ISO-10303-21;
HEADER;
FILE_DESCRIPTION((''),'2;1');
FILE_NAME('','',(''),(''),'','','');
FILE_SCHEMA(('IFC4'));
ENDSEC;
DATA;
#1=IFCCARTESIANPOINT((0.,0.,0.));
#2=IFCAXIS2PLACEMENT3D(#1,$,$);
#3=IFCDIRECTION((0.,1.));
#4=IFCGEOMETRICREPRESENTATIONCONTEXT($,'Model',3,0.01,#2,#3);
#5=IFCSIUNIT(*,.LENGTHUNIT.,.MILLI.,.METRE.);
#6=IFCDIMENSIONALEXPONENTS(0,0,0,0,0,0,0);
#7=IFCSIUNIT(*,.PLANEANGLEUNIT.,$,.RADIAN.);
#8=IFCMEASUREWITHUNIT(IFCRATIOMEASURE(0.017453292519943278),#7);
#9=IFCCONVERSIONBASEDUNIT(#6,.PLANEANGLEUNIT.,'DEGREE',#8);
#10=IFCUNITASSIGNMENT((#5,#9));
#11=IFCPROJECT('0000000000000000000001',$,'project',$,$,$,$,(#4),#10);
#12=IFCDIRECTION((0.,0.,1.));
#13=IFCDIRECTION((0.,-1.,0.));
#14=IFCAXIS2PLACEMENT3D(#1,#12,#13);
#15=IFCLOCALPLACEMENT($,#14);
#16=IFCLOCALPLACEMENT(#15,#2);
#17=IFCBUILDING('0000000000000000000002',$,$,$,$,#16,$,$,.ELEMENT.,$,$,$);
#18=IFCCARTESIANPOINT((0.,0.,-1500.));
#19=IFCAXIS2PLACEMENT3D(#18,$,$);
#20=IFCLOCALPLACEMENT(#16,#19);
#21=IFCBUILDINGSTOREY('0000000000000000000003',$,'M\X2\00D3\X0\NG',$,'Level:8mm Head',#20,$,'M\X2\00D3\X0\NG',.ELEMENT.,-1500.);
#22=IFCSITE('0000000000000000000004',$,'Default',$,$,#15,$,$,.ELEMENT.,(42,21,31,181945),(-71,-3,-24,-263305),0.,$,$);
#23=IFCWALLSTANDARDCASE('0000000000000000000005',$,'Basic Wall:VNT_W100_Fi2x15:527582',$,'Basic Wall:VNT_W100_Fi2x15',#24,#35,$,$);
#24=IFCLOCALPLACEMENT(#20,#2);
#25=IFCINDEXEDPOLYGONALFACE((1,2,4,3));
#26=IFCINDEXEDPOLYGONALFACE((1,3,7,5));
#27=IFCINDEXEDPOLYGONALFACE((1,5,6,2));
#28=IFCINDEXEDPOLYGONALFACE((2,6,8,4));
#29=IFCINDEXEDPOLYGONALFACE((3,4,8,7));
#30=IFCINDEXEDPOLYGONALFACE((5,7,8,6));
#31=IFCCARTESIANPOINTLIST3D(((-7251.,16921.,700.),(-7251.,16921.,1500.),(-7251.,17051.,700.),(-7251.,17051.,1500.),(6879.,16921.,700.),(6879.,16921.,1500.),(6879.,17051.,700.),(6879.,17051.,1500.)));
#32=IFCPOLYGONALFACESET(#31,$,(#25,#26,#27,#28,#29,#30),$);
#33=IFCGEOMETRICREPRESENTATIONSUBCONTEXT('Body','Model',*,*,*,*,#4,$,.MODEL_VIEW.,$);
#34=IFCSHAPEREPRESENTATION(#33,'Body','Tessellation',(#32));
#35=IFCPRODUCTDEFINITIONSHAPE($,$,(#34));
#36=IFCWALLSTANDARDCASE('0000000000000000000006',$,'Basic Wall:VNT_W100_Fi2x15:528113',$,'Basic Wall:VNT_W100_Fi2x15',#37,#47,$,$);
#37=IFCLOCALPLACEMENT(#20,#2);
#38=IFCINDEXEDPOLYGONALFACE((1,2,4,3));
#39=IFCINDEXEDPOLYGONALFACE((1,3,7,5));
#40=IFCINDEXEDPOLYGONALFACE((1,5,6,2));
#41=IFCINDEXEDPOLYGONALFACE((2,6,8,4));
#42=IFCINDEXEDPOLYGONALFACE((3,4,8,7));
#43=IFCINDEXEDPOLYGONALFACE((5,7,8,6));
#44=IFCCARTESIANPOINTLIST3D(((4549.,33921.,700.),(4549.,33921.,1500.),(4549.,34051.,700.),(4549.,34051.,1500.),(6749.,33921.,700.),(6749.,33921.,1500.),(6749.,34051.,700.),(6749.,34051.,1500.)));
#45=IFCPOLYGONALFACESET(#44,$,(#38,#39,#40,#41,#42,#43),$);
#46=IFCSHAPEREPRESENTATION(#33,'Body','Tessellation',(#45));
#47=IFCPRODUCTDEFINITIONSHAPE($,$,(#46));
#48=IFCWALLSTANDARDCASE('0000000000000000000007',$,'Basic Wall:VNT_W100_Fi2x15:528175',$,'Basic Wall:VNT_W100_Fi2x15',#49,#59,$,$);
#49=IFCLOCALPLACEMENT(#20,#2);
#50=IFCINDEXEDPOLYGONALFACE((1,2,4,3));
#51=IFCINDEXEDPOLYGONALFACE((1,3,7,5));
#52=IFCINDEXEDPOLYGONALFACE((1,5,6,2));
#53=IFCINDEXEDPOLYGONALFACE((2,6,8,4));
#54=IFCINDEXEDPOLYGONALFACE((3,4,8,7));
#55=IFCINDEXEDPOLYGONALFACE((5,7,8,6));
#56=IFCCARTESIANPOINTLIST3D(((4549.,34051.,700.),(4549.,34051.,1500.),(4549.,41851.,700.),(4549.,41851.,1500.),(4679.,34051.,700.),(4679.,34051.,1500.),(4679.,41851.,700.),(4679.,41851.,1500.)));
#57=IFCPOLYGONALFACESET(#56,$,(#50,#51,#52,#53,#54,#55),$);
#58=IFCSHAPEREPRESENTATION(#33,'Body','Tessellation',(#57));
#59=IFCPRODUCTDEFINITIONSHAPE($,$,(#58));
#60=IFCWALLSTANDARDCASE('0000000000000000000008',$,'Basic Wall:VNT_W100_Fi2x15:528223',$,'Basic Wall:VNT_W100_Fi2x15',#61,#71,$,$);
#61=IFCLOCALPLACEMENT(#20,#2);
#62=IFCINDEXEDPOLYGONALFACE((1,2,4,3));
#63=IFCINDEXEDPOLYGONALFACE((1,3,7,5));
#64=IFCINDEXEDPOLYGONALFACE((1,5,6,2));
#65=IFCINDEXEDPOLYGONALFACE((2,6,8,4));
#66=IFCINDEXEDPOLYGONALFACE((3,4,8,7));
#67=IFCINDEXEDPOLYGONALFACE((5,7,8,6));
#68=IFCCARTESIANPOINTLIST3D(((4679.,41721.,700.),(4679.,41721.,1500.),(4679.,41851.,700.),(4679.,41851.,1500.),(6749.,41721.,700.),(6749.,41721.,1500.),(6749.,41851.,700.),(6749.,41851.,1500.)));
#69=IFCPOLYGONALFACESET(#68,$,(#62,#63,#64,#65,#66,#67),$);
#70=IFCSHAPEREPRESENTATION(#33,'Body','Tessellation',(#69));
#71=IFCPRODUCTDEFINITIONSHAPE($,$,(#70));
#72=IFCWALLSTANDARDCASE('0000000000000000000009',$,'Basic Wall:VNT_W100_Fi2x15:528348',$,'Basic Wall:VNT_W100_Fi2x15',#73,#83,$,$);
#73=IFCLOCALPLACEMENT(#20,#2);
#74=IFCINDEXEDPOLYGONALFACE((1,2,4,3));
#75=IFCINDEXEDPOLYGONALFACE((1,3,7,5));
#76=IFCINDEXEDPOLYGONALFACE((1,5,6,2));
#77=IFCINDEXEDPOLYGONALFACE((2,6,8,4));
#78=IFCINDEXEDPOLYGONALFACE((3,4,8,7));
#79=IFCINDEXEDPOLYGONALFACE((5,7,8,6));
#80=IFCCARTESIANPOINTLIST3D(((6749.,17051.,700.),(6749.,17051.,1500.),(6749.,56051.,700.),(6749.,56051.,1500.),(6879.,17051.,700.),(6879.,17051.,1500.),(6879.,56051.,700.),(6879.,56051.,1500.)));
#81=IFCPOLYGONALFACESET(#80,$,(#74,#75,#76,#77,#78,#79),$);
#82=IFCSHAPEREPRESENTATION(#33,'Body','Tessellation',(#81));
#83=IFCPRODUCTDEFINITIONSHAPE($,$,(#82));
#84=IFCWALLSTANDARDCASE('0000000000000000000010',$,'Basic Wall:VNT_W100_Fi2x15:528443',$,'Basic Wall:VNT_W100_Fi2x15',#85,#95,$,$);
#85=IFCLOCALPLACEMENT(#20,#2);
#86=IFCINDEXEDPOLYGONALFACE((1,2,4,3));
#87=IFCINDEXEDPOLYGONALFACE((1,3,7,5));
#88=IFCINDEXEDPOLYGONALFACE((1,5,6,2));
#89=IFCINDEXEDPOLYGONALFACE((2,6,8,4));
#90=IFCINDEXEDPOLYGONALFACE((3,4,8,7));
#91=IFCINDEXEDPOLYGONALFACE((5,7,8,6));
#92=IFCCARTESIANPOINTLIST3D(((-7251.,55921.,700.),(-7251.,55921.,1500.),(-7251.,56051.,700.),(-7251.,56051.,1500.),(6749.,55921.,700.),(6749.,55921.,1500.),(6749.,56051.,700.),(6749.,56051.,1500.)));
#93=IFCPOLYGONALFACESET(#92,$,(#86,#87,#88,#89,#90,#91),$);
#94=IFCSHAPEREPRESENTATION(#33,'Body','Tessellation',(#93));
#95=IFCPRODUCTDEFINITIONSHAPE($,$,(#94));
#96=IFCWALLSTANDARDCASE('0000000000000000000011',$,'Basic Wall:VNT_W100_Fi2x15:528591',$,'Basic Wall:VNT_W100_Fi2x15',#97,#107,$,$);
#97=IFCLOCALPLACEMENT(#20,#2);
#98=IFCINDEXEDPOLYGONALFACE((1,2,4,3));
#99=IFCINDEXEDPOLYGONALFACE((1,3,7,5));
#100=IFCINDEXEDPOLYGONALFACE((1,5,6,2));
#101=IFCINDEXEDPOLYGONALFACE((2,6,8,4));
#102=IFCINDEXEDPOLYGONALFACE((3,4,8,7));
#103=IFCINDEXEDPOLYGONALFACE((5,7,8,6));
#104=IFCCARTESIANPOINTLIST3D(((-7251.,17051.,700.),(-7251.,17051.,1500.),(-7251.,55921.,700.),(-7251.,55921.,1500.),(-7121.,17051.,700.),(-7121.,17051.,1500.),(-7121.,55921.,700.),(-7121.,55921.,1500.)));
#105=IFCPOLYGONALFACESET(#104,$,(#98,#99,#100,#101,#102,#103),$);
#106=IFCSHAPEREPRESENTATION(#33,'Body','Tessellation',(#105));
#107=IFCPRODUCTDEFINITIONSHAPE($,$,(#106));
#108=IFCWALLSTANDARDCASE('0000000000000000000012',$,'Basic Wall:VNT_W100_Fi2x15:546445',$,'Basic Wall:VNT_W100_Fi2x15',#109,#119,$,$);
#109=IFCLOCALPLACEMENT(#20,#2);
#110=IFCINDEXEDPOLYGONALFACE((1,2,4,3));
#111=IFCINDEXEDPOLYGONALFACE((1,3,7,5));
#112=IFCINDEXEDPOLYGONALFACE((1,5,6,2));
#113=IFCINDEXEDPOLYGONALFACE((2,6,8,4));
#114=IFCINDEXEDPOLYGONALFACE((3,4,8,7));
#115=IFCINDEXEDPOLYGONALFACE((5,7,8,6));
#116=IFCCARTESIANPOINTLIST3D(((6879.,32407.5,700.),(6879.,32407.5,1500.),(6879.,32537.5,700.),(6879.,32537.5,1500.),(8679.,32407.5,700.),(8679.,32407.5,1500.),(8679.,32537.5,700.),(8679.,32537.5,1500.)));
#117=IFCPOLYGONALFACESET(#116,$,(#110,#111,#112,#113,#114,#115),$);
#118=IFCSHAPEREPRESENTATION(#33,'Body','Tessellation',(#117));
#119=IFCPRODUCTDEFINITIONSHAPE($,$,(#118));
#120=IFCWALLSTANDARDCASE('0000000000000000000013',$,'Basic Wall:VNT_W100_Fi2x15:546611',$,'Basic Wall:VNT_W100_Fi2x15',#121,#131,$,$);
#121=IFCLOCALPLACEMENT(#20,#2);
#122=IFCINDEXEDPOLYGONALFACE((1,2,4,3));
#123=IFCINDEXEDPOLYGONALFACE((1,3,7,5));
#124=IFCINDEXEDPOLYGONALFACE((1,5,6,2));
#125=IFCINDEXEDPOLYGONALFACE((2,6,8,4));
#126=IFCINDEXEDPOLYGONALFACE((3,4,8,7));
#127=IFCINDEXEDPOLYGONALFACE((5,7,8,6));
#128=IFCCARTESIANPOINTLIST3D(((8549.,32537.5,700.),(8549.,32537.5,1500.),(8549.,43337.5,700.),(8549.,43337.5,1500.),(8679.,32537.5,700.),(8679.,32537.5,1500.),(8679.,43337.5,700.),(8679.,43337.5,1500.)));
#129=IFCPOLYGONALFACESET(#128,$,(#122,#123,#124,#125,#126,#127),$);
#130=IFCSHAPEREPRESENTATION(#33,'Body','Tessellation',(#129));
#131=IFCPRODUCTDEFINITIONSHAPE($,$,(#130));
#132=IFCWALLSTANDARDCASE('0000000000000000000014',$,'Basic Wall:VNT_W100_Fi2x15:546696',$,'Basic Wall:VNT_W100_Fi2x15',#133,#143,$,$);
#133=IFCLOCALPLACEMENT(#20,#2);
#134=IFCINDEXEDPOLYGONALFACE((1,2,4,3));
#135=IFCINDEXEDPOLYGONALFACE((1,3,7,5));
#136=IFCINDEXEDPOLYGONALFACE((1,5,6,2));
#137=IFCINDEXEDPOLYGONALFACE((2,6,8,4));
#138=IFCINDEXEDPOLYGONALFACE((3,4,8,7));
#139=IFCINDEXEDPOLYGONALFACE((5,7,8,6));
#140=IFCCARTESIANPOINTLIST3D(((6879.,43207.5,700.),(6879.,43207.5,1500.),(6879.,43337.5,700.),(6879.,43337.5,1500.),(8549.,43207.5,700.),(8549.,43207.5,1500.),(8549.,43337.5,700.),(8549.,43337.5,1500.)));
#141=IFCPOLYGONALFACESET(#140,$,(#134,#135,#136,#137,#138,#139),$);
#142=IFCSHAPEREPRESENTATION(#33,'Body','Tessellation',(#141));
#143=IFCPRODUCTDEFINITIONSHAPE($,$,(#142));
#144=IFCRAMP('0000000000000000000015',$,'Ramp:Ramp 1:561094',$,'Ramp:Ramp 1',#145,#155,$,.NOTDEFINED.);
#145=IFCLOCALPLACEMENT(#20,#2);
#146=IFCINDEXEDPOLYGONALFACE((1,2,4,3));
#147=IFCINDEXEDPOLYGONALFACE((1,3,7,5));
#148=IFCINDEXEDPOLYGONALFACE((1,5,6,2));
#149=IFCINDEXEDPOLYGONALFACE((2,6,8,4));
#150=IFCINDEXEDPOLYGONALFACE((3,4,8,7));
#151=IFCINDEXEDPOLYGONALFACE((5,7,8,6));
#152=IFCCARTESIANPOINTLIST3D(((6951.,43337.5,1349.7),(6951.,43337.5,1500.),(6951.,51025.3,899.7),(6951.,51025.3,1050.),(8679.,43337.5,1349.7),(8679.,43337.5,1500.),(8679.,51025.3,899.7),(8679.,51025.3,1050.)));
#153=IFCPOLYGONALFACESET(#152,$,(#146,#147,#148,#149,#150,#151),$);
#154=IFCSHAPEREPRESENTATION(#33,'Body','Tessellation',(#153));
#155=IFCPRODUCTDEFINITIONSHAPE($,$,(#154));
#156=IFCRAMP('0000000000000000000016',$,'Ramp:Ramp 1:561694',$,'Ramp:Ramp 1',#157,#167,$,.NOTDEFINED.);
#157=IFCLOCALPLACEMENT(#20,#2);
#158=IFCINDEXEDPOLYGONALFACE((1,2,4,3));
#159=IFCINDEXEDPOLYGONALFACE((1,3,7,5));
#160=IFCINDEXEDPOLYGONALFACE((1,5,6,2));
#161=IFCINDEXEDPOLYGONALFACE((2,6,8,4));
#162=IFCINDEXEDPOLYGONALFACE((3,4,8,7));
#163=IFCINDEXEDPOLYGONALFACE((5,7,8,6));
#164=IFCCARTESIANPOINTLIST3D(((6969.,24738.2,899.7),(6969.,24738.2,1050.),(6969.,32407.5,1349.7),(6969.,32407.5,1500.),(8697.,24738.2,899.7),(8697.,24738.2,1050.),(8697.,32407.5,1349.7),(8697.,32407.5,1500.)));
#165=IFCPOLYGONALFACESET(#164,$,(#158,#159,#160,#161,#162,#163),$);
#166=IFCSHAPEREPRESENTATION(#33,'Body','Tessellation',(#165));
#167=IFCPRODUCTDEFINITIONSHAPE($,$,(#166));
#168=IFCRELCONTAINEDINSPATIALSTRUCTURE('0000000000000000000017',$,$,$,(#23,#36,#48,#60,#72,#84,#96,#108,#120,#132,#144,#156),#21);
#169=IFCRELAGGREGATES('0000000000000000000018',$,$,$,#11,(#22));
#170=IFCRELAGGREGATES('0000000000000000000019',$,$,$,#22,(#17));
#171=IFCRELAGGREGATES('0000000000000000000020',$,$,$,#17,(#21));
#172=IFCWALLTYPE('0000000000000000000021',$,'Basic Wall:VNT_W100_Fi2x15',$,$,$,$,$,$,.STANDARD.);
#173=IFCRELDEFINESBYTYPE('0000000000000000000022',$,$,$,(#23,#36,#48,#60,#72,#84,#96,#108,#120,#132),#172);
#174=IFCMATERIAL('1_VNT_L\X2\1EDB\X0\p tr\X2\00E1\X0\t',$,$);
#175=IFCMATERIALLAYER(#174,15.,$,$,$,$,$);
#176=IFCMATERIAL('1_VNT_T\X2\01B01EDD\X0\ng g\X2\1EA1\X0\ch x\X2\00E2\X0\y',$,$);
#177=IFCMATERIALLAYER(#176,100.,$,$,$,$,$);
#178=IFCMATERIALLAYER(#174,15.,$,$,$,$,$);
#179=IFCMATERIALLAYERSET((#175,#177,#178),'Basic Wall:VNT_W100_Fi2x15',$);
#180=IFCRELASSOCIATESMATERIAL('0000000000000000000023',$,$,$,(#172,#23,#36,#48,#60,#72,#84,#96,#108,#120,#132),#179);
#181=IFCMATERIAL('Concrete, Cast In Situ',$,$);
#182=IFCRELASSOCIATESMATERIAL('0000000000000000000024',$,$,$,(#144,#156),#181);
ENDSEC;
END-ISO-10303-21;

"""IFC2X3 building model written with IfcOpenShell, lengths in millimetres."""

from ifc_helpers import new_model, entity, si_unit, converted_unit, direction, frame, frame_2d, origin, place, context, subcontext, project, spatial, polyline, rectangle, outline, extrude, material, layer, layer_set, layer_usage, type_object, element, save


model = new_model("IFC2X3")

# Units and contexts
model_context = context("Model", 3, precision=0.01, world=origin(), true_north=direction((0.0, 1.0)))
body_context = subcontext(model_context, "Body", "Model", "MODEL_VIEW")
ifc_project = project(units=[si_unit("LENGTHUNIT", "METRE", prefix="MILLI"), converted_unit("PLANEANGLEUNIT", "DEGREE", entity("IfcRatioMeasure", 0.017453292519943278), si_unit("PLANEANGLEUNIT", "RADIAN"), dimensions=[0, 0, 0, 0, 0, 0, 0])], contexts=[model_context])

# Site, building, storey
site_placement = place(None, frame((0.0, 0.0, 0.0), z_axis=(0.0, 0.0, 1.0), x_axis=(0.0, -1.0, 0.0)))
site = spatial("IfcSite", under=ifc_project, at=site_placement, Name="Default", CompositionType="ELEMENT", RefLatitude=(42, 21, 31, 181945), RefLongitude=(-71, -3, -24, -263305), RefElevation=0.0)
building_placement = place(site_placement, origin())
building = spatial("IfcBuilding", under=site, at=building_placement, CompositionType="ELEMENT")
storey_placement = place(building_placement, frame((0.0, 0.0, -1500.0)))
storey = spatial("IfcBuildingStorey", under=building, at=storey_placement, Name="MÓNG", ObjectType="Level:8mm Head", LongName="MÓNG", CompositionType="ELEMENT", Elevation=-1500.0)

# Walls
ifc_material_1 = material(Name="1_VNT_Lớp trát")
ifc_layer_1 = layer(ifc_material_1, 15.0)
ifc_material_2 = material(Name="1_VNT_Tường gạch xây")
ifc_layer_2 = layer(ifc_material_2, 100.0)
ifc_layer_3 = layer(ifc_material_1, 15.0)
ifc_layer_set = layer_set([ifc_layer_1, ifc_layer_2, ifc_layer_3], Name="Basic Wall:VNT_W100_Fi2x15")
ifc_layer_usage = layer_usage(ifc_layer_set, "AXIS2", "NEGATIVE", 65.0)
wall_type = type_object("IfcWallType", Name="Basic Wall:VNT_W100_Fi2x15", PredefinedType="STANDARD", material=ifc_layer_set)
wall_1_placement = place(storey_placement, frame((-7251.0, 16986.0, 700.0)))
element("IfcWallStandardCase", 1, at=wall_1_placement, inside=storey, type_object=wall_type, material=ifc_layer_usage, Name="Basic Wall:VNT_W100_Fi2x15:527582", ObjectType="Basic Wall:VNT_W100_Fi2x15", context=body_context, shape_type="SweptSolid", body=[
    extrude(rectangle(XDim=14130.0, YDim=130.0, at=frame_2d((7065.0, 0.0), x_axis=(-1.0, 0.0))), origin(), (0.0, 0.0, 1.0), 800.0),
])
wall_2_placement = place(storey_placement, frame((6749.0, 33986.0, 700.0), z_axis=(0.0, 0.0, 1.0), x_axis=(-1.0, 0.0, 0.0)))
element("IfcWallStandardCase", 2, at=wall_2_placement, inside=storey, type_object=wall_type, material=ifc_layer_usage, Name="Basic Wall:VNT_W100_Fi2x15:528113", ObjectType="Basic Wall:VNT_W100_Fi2x15", context=body_context, shape_type="SweptSolid", body=[
    extrude(rectangle(XDim=2200.0, YDim=130.0, at=frame_2d((1100.0, 0.0), x_axis=(-1.0, 0.0))), origin(), (0.0, 0.0, 1.0), 800.0),
])
wall_3_placement = place(storey_placement, frame((4614.0, 34051.0, 700.0), z_axis=(0.0, 0.0, 1.0), x_axis=(0.0, 1.0, 0.0)))
element("IfcWallStandardCase", 3, at=wall_3_placement, inside=storey, type_object=wall_type, material=ifc_layer_usage, Name="Basic Wall:VNT_W100_Fi2x15:528175", ObjectType="Basic Wall:VNT_W100_Fi2x15", context=body_context, shape_type="SweptSolid", body=[
    extrude(rectangle(XDim=7800.0, YDim=130.0, at=frame_2d((3900.0, 0.0), x_axis=(-1.0, 0.0))), origin(), (0.0, 0.0, 1.0), 800.0),
])
wall_4_placement = place(storey_placement, frame((4679.0, 41786.0, 700.0)))
element("IfcWallStandardCase", 4, at=wall_4_placement, inside=storey, type_object=wall_type, material=ifc_layer_usage, Name="Basic Wall:VNT_W100_Fi2x15:528223", ObjectType="Basic Wall:VNT_W100_Fi2x15", context=body_context, shape_type="SweptSolid", body=[
    extrude(rectangle(XDim=2070.0, YDim=130.0, at=frame_2d((1035.0, 0.0), x_axis=(-1.0, 0.0))), origin(), (0.0, 0.0, 1.0), 800.0),
])
wall_5_placement = place(storey_placement, frame((6814.0, 17051.0, 700.0), z_axis=(0.0, 0.0, 1.0), x_axis=(0.0, 1.0, 0.0)))
element("IfcWallStandardCase", 5, at=wall_5_placement, inside=storey, type_object=wall_type, material=ifc_layer_usage, Name="Basic Wall:VNT_W100_Fi2x15:528348", ObjectType="Basic Wall:VNT_W100_Fi2x15", context=body_context, shape_type="SweptSolid", body=[
    extrude(rectangle(XDim=39000.0, YDim=130.0, at=frame_2d((19500.0, 0.0), x_axis=(-1.0, 0.0))), origin(), (0.0, 0.0, 1.0), 800.0),
])
wall_6_placement = place(storey_placement, frame((6749.0, 55986.0, 700.0), z_axis=(0.0, 0.0, 1.0), x_axis=(-1.0, 0.0, 0.0)))
element("IfcWallStandardCase", 6, at=wall_6_placement, inside=storey, type_object=wall_type, material=ifc_layer_usage, Name="Basic Wall:VNT_W100_Fi2x15:528443", ObjectType="Basic Wall:VNT_W100_Fi2x15", context=body_context, shape_type="SweptSolid", body=[
    extrude(rectangle(XDim=14000.0, YDim=130.0, at=frame_2d((7000.0, 0.0), x_axis=(-1.0, 0.0))), origin(), (0.0, 0.0, 1.0), 800.0),
])
wall_7_placement = place(storey_placement, frame((-7186.0, 55921.0, 700.0), z_axis=(0.0, 0.0, 1.0), x_axis=(0.0, -1.0, 0.0)))
element("IfcWallStandardCase", 7, at=wall_7_placement, inside=storey, type_object=wall_type, material=ifc_layer_usage, Name="Basic Wall:VNT_W100_Fi2x15:528591", ObjectType="Basic Wall:VNT_W100_Fi2x15", context=body_context, shape_type="SweptSolid", body=[
    extrude(rectangle(XDim=38870.0, YDim=130.0, at=frame_2d((19435.0, 0.0), x_axis=(-1.0, 0.0))), origin(), (0.0, 0.0, 1.0), 800.0),
])
wall_8_placement = place(storey_placement, frame((6879.0, 32472.5, 700.0)))
element("IfcWallStandardCase", 8, at=wall_8_placement, inside=storey, type_object=wall_type, material=ifc_layer_usage, Name="Basic Wall:VNT_W100_Fi2x15:546445", ObjectType="Basic Wall:VNT_W100_Fi2x15", context=body_context, shape_type="SweptSolid", body=[
    extrude(rectangle(XDim=1800.0, YDim=130.0, at=frame_2d((900.0, 0.0), x_axis=(-1.0, 0.0))), origin(), (0.0, 0.0, 1.0), 800.0),
])
wall_9_placement = place(storey_placement, frame((8614.0, 32537.5, 700.0), z_axis=(0.0, 0.0, 1.0), x_axis=(0.0, 1.0, 0.0)))
element("IfcWallStandardCase", 9, at=wall_9_placement, inside=storey, type_object=wall_type, material=ifc_layer_usage, Name="Basic Wall:VNT_W100_Fi2x15:546611", ObjectType="Basic Wall:VNT_W100_Fi2x15", context=body_context, shape_type="SweptSolid", body=[
    extrude(rectangle(XDim=10800.0, YDim=130.0, at=frame_2d((5400.0, 0.0), x_axis=(-1.0, 0.0))), origin(), (0.0, 0.0, 1.0), 800.0),
])
wall_10_placement = place(storey_placement, frame((8549.0, 43272.5, 700.0), z_axis=(0.0, 0.0, 1.0), x_axis=(-1.0, 0.0, 0.0)))
element("IfcWallStandardCase", 10, at=wall_10_placement, inside=storey, type_object=wall_type, material=ifc_layer_usage, Name="Basic Wall:VNT_W100_Fi2x15:546696", ObjectType="Basic Wall:VNT_W100_Fi2x15", context=body_context, shape_type="SweptSolid", body=[
    extrude(rectangle(XDim=1670.0, YDim=130.0, at=frame_2d((835.0, 0.0), x_axis=(-1.0, 0.0))), origin(), (0.0, 0.0, 1.0), 800.0),
])

# Ramps
ifc_material_3 = material(Name="Concrete, Cast In Situ")
ramp_1_placement = place(storey_placement, origin())
element("IfcRamp", 11, at=ramp_1_placement, inside=storey, material=ifc_material_3, Name="Ramp:Ramp 1:561094", ObjectType="Ramp:Ramp 1", ShapeType="NOTDEFINED", context=body_context, shape_type="SweptSolid", body=[
    extrude(outline(polyline([(-300.1, -3843.9), (-149.9, -3843.9), (300.1, 3843.9), (149.9, 3843.9), (-300.1, -3843.9)])), frame((6951.0, 47181.4, 1199.9), z_axis=(1.0, 0.0, 0.0), x_axis=(0.0, 0.0, -1.0)), (0.0, 0.0, 1.0), 1728.0),
])
ramp_2_placement = place(storey_placement, origin())
element("IfcRamp", 12, at=ramp_2_placement, inside=storey, material=ifc_material_3, Name="Ramp:Ramp 1:561694", ObjectType="Ramp:Ramp 1", ShapeType="NOTDEFINED", context=body_context, shape_type="SweptSolid", body=[
    extrude(outline(polyline([(149.9, -3834.6), (300.1, -3834.6), (-149.9, 3834.6), (-300.1, 3834.6), (149.9, -3834.6)])), frame((6969.0, 28572.9, 1199.9), z_axis=(1.0, 0.0, 0.0), x_axis=(0.0, 0.0, -1.0)), (0.0, 0.0, 1.0), 1728.0),
])

save(model, "model.ifc")
